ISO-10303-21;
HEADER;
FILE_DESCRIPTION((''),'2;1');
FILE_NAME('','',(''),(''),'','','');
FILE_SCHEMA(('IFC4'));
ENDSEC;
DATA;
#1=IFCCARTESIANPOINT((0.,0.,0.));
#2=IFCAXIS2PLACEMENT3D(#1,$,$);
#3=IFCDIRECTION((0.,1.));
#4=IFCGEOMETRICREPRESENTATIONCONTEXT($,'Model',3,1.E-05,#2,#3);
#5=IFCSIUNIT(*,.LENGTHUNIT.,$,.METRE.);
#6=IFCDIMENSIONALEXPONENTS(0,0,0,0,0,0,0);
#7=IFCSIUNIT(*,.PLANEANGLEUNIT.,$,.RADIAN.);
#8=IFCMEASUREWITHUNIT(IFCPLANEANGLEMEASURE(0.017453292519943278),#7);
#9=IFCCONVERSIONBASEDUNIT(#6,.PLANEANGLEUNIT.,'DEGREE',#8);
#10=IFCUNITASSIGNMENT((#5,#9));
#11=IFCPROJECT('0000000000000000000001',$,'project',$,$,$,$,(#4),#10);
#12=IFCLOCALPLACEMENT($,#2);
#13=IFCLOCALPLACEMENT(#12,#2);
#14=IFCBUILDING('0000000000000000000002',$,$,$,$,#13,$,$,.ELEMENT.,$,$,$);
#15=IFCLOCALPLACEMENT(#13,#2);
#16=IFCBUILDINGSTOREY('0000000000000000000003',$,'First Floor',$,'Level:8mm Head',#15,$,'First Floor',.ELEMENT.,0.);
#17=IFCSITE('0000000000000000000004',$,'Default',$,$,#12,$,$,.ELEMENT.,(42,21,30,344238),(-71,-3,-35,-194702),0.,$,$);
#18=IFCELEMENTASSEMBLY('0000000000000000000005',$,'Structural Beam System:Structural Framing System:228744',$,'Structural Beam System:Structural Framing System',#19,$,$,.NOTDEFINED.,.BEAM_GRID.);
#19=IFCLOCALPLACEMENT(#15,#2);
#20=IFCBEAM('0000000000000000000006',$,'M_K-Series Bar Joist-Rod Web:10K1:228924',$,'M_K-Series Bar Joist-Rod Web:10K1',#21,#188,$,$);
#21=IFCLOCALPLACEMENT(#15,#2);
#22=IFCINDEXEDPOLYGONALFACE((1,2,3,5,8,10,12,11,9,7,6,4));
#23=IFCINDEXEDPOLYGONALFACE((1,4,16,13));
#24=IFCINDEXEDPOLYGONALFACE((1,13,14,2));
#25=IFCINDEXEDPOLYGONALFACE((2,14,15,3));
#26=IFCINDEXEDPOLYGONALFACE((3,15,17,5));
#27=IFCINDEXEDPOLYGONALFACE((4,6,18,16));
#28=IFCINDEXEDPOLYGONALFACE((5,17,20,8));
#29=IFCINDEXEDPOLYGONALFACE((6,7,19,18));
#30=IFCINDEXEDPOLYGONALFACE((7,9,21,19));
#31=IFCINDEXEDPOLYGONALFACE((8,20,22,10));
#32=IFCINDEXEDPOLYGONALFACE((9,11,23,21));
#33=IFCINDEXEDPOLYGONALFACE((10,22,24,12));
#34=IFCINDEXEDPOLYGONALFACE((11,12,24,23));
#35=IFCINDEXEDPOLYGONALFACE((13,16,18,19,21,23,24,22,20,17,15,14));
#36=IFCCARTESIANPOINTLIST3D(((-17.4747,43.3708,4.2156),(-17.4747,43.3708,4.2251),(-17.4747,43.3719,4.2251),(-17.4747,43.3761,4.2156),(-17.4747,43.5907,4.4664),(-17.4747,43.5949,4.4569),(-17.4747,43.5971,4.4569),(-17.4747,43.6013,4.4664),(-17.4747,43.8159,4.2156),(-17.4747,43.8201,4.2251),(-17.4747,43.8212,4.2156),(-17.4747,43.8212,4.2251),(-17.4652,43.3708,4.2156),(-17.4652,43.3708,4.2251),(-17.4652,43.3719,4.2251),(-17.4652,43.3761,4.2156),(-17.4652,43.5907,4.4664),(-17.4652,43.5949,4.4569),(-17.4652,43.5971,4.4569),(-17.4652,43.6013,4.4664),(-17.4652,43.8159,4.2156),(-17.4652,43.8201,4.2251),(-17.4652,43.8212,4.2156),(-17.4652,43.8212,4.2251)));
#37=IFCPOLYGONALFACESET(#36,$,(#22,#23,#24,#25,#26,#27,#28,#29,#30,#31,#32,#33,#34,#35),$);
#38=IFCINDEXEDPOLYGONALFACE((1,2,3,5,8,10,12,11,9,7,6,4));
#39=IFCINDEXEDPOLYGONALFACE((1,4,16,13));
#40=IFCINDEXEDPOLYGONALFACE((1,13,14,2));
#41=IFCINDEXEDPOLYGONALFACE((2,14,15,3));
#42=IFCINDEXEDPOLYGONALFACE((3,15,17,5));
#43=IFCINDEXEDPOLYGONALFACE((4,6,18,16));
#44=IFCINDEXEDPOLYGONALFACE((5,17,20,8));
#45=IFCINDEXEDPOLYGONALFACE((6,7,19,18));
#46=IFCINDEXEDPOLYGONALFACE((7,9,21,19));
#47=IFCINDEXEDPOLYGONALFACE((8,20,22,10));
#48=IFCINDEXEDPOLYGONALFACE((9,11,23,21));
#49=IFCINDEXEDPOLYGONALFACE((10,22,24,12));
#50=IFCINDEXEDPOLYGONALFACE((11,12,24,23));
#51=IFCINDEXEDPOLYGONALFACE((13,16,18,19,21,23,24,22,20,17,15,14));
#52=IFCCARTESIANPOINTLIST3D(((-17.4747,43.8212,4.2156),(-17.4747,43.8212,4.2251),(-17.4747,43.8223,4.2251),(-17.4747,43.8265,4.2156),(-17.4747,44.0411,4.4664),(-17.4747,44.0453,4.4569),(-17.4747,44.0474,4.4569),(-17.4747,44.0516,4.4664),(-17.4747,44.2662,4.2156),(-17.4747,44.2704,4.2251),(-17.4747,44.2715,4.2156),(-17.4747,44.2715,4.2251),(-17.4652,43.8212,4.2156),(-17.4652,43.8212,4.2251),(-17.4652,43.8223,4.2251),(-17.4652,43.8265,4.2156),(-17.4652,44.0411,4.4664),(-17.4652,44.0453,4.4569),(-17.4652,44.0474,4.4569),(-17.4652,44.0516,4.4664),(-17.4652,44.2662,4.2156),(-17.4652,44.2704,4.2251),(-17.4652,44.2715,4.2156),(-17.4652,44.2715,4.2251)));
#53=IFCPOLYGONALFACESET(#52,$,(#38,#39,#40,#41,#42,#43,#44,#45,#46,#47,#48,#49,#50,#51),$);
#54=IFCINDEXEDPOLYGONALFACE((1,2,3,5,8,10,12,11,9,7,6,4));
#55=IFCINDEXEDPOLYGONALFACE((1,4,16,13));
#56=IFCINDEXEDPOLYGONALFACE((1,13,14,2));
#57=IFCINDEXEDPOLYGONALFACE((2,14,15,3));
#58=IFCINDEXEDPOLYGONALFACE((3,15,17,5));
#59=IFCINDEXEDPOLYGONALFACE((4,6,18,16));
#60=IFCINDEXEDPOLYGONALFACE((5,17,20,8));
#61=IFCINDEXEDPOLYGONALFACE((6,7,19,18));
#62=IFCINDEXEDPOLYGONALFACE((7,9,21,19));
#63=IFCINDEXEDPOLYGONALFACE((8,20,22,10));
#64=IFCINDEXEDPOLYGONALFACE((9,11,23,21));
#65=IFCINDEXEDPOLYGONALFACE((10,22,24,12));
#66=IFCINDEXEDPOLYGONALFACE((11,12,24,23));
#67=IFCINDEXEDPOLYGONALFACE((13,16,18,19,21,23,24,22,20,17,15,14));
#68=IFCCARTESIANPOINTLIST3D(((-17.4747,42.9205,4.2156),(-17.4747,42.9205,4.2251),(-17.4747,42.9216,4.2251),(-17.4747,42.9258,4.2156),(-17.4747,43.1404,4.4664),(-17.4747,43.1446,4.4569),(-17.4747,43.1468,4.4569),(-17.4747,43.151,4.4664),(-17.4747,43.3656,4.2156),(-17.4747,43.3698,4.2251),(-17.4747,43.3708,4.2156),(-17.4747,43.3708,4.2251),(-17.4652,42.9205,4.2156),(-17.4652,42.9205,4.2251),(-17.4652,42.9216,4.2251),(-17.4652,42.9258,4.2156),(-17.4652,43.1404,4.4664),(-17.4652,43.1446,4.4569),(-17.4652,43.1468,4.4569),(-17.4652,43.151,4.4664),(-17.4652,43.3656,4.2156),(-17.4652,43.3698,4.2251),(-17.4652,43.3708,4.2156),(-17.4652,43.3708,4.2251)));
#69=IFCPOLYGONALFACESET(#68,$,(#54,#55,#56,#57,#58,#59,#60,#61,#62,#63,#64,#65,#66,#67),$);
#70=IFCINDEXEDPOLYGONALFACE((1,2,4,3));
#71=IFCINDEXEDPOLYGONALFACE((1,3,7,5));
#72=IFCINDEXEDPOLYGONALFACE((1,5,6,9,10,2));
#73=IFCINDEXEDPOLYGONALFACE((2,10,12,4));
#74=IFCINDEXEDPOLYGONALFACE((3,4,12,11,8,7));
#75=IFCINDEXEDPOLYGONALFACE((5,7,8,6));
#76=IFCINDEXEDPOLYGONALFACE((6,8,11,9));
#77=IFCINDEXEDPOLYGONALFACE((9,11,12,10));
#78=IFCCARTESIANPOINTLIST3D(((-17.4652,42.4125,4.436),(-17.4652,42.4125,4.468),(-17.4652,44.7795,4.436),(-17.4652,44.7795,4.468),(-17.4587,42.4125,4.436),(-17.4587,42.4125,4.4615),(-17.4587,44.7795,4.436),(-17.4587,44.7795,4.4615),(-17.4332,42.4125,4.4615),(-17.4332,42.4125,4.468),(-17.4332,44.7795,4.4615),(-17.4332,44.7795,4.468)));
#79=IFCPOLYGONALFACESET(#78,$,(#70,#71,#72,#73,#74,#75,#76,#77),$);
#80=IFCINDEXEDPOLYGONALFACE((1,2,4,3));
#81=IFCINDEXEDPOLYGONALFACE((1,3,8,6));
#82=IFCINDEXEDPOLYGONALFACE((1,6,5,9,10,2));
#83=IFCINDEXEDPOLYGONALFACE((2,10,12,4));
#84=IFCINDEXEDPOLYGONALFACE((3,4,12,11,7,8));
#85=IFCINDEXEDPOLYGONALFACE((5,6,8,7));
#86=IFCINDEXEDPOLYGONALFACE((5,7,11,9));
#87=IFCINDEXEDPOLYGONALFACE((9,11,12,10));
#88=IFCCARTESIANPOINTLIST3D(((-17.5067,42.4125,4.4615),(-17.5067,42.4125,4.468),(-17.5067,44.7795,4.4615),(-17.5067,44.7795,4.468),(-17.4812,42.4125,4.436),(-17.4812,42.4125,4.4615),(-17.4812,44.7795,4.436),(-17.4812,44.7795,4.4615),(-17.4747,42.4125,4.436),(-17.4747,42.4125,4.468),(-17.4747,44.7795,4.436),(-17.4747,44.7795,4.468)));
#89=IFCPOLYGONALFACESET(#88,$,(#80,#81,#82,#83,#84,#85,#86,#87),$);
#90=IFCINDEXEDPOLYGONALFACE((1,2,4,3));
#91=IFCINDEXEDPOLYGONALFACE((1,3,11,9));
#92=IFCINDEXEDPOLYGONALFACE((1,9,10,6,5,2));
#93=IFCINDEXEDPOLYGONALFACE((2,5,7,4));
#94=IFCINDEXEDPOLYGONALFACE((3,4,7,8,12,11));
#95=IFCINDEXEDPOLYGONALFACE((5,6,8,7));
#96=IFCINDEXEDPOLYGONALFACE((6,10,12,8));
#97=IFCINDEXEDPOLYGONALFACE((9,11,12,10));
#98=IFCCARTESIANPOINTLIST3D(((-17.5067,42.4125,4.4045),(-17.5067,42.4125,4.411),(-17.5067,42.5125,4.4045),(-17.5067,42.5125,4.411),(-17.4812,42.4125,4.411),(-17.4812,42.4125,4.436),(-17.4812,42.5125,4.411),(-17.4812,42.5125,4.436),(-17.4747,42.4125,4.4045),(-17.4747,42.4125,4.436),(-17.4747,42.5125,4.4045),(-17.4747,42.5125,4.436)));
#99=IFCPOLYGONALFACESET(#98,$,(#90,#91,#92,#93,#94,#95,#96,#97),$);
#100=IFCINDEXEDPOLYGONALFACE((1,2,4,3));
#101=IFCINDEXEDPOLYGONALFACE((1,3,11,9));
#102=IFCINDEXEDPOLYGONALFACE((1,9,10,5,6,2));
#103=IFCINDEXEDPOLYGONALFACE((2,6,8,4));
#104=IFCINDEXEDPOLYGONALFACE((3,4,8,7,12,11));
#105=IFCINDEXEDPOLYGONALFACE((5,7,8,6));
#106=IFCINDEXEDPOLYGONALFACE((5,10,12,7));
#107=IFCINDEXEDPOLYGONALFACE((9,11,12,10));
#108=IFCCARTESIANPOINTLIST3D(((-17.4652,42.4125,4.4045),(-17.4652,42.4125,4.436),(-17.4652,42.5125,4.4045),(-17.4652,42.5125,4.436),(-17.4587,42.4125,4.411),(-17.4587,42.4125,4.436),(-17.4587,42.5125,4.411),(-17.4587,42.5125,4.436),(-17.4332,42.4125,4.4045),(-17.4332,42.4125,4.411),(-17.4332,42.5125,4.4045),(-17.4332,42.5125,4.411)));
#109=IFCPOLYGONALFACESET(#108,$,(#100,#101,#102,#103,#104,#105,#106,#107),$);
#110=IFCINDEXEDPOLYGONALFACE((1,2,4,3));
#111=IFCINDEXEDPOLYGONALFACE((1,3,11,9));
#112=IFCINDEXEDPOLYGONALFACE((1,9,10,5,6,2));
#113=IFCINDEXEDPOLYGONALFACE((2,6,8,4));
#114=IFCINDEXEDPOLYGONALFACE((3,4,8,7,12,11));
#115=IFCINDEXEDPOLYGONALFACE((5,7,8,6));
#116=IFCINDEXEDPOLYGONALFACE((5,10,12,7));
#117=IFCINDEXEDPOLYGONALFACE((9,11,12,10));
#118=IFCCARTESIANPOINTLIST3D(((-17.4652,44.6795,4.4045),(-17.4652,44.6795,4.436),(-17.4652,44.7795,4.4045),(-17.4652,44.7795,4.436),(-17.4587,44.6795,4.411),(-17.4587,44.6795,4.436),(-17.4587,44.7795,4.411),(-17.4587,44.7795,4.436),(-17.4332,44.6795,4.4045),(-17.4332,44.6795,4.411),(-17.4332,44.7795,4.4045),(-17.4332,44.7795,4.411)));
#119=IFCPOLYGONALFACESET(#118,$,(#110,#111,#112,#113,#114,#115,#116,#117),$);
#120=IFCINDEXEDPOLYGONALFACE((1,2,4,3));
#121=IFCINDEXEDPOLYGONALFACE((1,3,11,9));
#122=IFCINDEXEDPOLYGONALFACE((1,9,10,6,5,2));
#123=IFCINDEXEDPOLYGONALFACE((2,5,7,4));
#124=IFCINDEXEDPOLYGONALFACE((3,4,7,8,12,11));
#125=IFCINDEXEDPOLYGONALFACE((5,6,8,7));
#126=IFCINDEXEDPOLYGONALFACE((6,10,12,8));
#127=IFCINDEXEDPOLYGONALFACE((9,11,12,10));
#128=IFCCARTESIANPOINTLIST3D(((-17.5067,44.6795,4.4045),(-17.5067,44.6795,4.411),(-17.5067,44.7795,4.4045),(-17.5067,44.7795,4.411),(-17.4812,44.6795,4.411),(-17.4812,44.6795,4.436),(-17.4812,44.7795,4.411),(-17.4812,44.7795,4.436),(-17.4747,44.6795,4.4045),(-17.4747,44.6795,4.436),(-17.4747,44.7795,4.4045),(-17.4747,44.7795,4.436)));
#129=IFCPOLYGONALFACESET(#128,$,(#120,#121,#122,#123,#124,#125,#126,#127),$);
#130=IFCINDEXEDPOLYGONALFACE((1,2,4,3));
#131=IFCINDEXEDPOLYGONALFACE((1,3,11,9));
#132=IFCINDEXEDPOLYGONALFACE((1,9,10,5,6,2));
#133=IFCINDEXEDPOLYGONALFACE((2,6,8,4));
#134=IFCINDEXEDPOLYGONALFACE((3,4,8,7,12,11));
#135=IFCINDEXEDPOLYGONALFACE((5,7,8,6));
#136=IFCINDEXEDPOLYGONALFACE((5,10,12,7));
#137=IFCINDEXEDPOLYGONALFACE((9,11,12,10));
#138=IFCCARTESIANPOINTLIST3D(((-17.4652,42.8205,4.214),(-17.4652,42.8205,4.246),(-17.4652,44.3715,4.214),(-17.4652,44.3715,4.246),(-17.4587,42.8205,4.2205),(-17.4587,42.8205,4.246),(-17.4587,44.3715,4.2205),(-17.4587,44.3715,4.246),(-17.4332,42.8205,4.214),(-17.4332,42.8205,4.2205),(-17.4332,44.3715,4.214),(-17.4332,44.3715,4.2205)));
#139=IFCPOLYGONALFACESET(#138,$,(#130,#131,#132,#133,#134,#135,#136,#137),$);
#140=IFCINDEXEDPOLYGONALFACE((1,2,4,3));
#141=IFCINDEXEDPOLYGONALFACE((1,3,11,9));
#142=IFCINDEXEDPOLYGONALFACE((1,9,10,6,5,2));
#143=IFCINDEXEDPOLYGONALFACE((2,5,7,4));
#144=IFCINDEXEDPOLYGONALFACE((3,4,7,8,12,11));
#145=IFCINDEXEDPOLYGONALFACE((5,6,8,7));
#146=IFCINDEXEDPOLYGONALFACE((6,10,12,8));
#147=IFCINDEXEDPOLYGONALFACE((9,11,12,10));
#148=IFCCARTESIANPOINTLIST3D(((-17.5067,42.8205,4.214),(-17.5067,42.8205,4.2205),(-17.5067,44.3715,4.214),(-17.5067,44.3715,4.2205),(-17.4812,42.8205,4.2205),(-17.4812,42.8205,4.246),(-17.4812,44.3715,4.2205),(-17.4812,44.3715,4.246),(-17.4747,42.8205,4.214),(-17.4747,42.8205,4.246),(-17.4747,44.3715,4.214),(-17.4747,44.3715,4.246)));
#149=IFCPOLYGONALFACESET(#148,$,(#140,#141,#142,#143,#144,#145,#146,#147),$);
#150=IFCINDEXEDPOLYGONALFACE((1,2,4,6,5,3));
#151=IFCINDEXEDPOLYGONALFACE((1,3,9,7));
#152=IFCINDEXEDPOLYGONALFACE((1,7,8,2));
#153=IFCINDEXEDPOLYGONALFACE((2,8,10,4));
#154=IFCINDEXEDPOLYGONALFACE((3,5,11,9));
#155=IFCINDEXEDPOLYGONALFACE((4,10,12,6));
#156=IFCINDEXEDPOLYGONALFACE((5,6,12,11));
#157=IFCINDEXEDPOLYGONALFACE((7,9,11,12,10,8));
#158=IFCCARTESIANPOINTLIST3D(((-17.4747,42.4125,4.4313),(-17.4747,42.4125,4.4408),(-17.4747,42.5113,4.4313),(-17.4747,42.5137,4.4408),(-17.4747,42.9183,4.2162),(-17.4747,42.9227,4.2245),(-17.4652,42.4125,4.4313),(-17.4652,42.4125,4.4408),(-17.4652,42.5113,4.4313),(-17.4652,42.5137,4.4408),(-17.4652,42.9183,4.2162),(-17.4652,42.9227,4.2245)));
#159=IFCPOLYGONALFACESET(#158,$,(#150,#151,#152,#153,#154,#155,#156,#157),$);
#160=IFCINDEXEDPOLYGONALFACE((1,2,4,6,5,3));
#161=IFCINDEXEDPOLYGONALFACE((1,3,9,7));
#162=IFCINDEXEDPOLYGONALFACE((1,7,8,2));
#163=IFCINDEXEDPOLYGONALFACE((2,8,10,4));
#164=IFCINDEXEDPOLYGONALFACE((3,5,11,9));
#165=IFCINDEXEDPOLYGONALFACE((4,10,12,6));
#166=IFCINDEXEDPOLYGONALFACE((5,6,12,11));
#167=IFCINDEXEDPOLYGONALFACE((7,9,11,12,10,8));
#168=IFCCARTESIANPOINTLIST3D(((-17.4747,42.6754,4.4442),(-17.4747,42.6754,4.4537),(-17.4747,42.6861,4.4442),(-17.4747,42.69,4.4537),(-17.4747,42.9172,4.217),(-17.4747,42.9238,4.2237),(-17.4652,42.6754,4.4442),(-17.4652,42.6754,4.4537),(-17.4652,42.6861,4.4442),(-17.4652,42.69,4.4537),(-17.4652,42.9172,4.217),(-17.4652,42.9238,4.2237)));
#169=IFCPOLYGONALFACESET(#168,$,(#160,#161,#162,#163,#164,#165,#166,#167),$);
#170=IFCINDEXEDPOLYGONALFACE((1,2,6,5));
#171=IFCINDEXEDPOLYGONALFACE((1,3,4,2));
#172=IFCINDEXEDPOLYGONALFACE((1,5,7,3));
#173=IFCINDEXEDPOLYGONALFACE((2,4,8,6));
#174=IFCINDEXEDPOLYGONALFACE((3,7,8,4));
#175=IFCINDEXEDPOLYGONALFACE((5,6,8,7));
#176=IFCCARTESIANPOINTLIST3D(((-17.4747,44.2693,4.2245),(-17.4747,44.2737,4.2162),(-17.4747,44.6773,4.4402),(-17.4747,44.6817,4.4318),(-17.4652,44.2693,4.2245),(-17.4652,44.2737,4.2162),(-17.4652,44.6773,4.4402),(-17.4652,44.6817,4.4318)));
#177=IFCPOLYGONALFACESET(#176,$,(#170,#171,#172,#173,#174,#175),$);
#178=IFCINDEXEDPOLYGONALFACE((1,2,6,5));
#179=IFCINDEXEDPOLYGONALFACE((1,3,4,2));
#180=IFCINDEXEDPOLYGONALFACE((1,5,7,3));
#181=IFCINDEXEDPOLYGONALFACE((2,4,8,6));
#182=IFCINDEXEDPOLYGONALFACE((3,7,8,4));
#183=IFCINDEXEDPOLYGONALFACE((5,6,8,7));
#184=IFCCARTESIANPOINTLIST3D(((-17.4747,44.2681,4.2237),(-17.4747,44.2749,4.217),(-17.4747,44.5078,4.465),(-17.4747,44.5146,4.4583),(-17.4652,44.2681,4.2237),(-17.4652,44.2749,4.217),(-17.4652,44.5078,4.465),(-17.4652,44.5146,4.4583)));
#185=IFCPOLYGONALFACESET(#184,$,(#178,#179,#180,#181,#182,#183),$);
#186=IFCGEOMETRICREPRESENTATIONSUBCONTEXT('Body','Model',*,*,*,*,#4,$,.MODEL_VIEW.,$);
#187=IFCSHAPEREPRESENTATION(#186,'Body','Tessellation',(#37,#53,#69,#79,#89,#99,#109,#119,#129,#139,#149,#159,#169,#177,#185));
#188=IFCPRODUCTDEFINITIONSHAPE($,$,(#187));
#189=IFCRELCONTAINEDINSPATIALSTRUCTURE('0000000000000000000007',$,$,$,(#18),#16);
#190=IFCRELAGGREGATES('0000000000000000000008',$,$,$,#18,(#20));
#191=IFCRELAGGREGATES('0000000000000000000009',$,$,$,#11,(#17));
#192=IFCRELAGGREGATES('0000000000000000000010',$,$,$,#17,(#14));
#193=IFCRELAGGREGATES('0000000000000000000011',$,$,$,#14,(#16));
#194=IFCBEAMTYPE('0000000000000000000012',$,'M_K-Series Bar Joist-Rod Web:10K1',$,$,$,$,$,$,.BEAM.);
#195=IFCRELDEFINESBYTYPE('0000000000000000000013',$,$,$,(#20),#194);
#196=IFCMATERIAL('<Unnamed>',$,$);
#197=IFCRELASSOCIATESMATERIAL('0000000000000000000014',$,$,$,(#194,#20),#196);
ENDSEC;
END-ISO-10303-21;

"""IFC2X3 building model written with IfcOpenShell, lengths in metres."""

from ifc_helpers import new_model, entity, si_unit, converted_unit, direction, frame, frame_2d, origin, place, context, subcontext, project, spatial, polyline, rectangle, outline, extrude, source, transform, mapped, material, type_object, type_shapes, element, aggregate, save


model = new_model("IFC2X3")

# Units and contexts
model_context = context("Model", 3, precision=1e-05, world=origin(), true_north=direction((0.0, 1.0)))
body_context = subcontext(model_context, "Body", "Model", "MODEL_VIEW")
ifc_project = project(units=[si_unit("LENGTHUNIT", "METRE"), converted_unit("PLANEANGLEUNIT", "DEGREE", entity("IfcPlaneAngleMeasure", 0.017453292519943278), si_unit("PLANEANGLEUNIT", "RADIAN"), dimensions=[0, 0, 0, 0, 0, 0, 0])], contexts=[model_context])

# Site, building, storey
site_placement = place(None, origin())
site = spatial("IfcSite", under=ifc_project, at=site_placement, Name="Default", CompositionType="ELEMENT", RefLatitude=(42, 21, 30, 344238), RefLongitude=(-71, -3, -35, -194702), RefElevation=0.0)
building_placement = place(site_placement, origin())
building = spatial("IfcBuilding", under=site, at=building_placement, CompositionType="ELEMENT")
storey_placement = place(building_placement, origin())
storey = spatial("IfcBuildingStorey", under=building, at=storey_placement, Name="First Floor", ObjectType="Level:8mm Head", LongName="First Floor", CompositionType="ELEMENT", Elevation=0.0)

# Shared definitions
ifc_material_1 = material(Name="<Unnamed>")

# Element assembly, beam
assembly_1_placement = place(storey_placement, origin())
assembly_1 = element("IfcElementAssembly", 1, at=assembly_1_placement, inside=storey, Name="Structural Beam System:Structural Framing System:228744", ObjectType="Structural Beam System:Structural Framing System", AssemblyPlace="NOTDEFINED", PredefinedType="BEAM_GRID")
beam_type_1 = type_object("IfcBeamType", Name="M_K-Series Bar Joist-Rod Web:10K1", PredefinedType="BEAM", material=ifc_material_1)
shared_shape_1 = source(origin(), body_context, "Body", "SweptSolid", [
    extrude(outline(polyline([(-0.2252, -0.0757), (-0.2252, -0.0852), (-0.2199, -0.0852), (-0.0011, 0.1561), (0.0011, 0.1561), (0.2199, -0.0852), (0.2252, -0.0852), (0.2252, -0.0757), (0.2241, -0.0757), (0.0053, 0.1656), (-0.0053, 0.1656), (-0.2241, -0.0757), (-0.2252, -0.0757)])), frame((0.0, -0.0047, -0.0402), z_axis=(0.0, -1.0, 0.0), x_axis=(1.0, 0.0, 0.0)), (0.0, 0.0, -1.0), 0.0095),
    extrude(outline(polyline([(-0.2252, -0.0757), (-0.2252, -0.0852), (-0.2199, -0.0852), (-0.0011, 0.1561), (0.0011, 0.1561), (0.2199, -0.0852), (0.2252, -0.0852), (0.2252, -0.0757), (0.2241, -0.0757), (0.0053, 0.1656), (-0.0053, 0.1656), (-0.2241, -0.0757), (-0.2252, -0.0757)])), frame((0.4503, -0.0047, -0.0402), z_axis=(0.0, -1.0, 0.0), x_axis=(1.0, 0.0, 0.0)), (0.0, 0.0, -1.0), 0.0095),
    extrude(outline(polyline([(-0.2252, -0.0757), (-0.2252, -0.0852), (-0.2199, -0.0852), (-0.0011, 0.1561), (0.0011, 0.1561), (0.2199, -0.0852), (0.2252, -0.0852), (0.2252, -0.0757), (0.2241, -0.0757), (0.0053, 0.1656), (-0.0053, 0.1656), (-0.2241, -0.0757), (-0.2252, -0.0757)])), frame((-0.4503, -0.0047, -0.0402), z_axis=(0.0, -1.0, 0.0), x_axis=(1.0, 0.0, 0.0)), (0.0, 0.0, -1.0), 0.0095),
    extrude(outline(polyline([(-0.0128, -0.0128), (0.0192, -0.0128), (0.0192, -0.0063), (-0.0063, -0.0063), (-0.0063, 0.0192), (-0.0128, 0.0192), (-0.0128, -0.0128)])), frame((-1.1835, -0.0176, 0.1142), z_axis=(1.0, 0.0, 0.0), x_axis=(0.0, -1.0, 0.0)), (0.0, 0.0, 1.0), 2.367),
    extrude(outline(polyline([(-0.0128, -0.0128), (0.0192, -0.0128), (0.0192, -0.0063), (-0.0063, -0.0063), (-0.0063, 0.0192), (-0.0128, 0.0192), (-0.0128, -0.0128)])), frame((-1.1835, 0.0176, 0.1142), z_axis=(1.0, 0.0, 0.0), x_axis=(0.0, 0.0, -1.0)), (0.0, 0.0, 1.0), 2.367),
    extrude(outline(polyline([(-0.0127, -0.0192), (-0.0062, -0.0192), (-0.0062, 0.0063), (0.0188, 0.0063), (0.0188, 0.0128), (-0.0127, 0.0128), (-0.0127, -0.0192)])), frame((-1.1835, 0.0176, 0.0762), z_axis=(1.0, 0.0, 0.0), x_axis=(0.0, 0.0, 1.0)), (0.0, 0.0, 1.0), 0.1),
    extrude(outline(polyline([(-0.0127, -0.0128), (0.0188, -0.0128), (0.0188, -0.0063), (-0.0062, -0.0063), (-0.0062, 0.0192), (-0.0127, 0.0192), (-0.0127, -0.0128)])), frame((-1.1835, -0.0176, 0.0762), z_axis=(1.0, 0.0, 0.0), x_axis=(0.0, 0.0, 1.0)), (0.0, 0.0, 1.0), 0.1),
    extrude(outline(polyline([(-0.0127, -0.0128), (0.0188, -0.0128), (0.0188, -0.0063), (-0.0062, -0.0063), (-0.0062, 0.0192), (-0.0127, 0.0192), (-0.0127, -0.0128)])), frame((1.0835, -0.0176, 0.0762), z_axis=(1.0, 0.0, 0.0), x_axis=(0.0, 0.0, 1.0)), (0.0, 0.0, 1.0), 0.1),
    extrude(outline(polyline([(-0.0128, -0.0127), (0.0192, -0.0127), (0.0192, -0.0062), (-0.0063, -0.0062), (-0.0063, 0.0188), (-0.0128, 0.0188), (-0.0128, -0.0127)])), frame((1.0835, 0.0176, 0.0762), z_axis=(1.0, 0.0, 0.0), x_axis=(0.0, 1.0, 0.0)), (0.0, 0.0, 1.0), 0.1),
    extrude(outline(polyline([(-0.0128, -0.0128), (0.0192, -0.0128), (0.0192, -0.0063), (-0.0063, -0.0063), (-0.0063, 0.0192), (-0.0128, 0.0192), (-0.0128, -0.0128)])), frame((-0.7755, -0.0176, -0.1142), z_axis=(1.0, 0.0, 0.0), x_axis=(0.0, 0.0, 1.0)), (0.0, 0.0, 1.0), 1.551),
    extrude(outline(polyline([(-0.0128, -0.0128), (0.0192, -0.0128), (0.0192, -0.0063), (-0.0063, -0.0063), (-0.0063, 0.0192), (-0.0128, 0.0192), (-0.0128, -0.0128)])), frame((-0.7755, 0.0176, -0.1142), z_axis=(1.0, 0.0, 0.0), x_axis=(0.0, 1.0, 0.0)), (0.0, 0.0, 1.0), 1.551),
    extrude(outline(polyline([(-0.3371, -0.0108), (-0.3371, -0.0203), (0.1255, -0.0203), (0.215, 0.027), (0.2105, 0.0354), (0.1232, -0.0108), (-0.3371, -0.0108)])), frame((-0.9808, -0.0048, 0.0231), z_axis=(0.0, -1.0, 0.0), x_axis=(-0.884101, 0.0, 0.467295)), (0.0, 0.0, -1.0), 0.0095),
    extrude(outline(polyline([(-0.0859, -0.0809), (-0.0713, -0.0809), (0.1625, 0.149), (0.1559, 0.1558), (-0.0752, -0.0714), (-0.0859, -0.0714), (-0.0859, -0.0809)])), frame((-0.8347, -0.0047, 0.0318), z_axis=(0.0, 1.0, 0.0), x_axis=(1.0, 0.0, 0.0)), (0.0, 0.0, 1.0), 0.0095),
    extrude(rectangle(XDim=0.0095, YDim=0.0095, at=frame_2d((0.0, 0.0), x_axis=(0.0, 1.0))), frame((0.6755, 0.0, -0.1206), z_axis=(0.884101, 0.0, 0.467295), x_axis=(0.0, 1.0, 0.0)), (0.0, 0.0, 1.0), 0.4615),
    extrude(rectangle(XDim=0.3401, YDim=0.0095, at=frame_2d((0.0, 0.0), x_axis=(1.0, 0.0))), frame((0.7953, -0.0047, 0.0), z_axis=(0.0, 1.0, 0.0), x_axis=(-0.704723, 0.0, -0.709483)), (0.0, 0.0, 1.0), 0.0095),
])
type_shapes(beam_type_1, [shared_shape_1])
beam_1_placement = place(assembly_1_placement, frame((-17.47, 43.596, 4.341), z_axis=(0.0, 0.0, 1.0), x_axis=(0.0, 1.0, 0.0)))
beam_1 = element("IfcBeam", 2, at=beam_1_placement, type_object=beam_type_1, material=ifc_material_1, Name="M_K-Series Bar Joist-Rod Web:10K1:228924", ObjectType="M_K-Series Bar Joist-Rod Web:10K1", context=body_context, shape_type="MappedRepresentation", body=[
    mapped(shared_shape_1, transform((0.0, 0.0, 0.0), scale=1.0)),
])
aggregate(assembly_1, [beam_1])

save(model, "model.ifc")
